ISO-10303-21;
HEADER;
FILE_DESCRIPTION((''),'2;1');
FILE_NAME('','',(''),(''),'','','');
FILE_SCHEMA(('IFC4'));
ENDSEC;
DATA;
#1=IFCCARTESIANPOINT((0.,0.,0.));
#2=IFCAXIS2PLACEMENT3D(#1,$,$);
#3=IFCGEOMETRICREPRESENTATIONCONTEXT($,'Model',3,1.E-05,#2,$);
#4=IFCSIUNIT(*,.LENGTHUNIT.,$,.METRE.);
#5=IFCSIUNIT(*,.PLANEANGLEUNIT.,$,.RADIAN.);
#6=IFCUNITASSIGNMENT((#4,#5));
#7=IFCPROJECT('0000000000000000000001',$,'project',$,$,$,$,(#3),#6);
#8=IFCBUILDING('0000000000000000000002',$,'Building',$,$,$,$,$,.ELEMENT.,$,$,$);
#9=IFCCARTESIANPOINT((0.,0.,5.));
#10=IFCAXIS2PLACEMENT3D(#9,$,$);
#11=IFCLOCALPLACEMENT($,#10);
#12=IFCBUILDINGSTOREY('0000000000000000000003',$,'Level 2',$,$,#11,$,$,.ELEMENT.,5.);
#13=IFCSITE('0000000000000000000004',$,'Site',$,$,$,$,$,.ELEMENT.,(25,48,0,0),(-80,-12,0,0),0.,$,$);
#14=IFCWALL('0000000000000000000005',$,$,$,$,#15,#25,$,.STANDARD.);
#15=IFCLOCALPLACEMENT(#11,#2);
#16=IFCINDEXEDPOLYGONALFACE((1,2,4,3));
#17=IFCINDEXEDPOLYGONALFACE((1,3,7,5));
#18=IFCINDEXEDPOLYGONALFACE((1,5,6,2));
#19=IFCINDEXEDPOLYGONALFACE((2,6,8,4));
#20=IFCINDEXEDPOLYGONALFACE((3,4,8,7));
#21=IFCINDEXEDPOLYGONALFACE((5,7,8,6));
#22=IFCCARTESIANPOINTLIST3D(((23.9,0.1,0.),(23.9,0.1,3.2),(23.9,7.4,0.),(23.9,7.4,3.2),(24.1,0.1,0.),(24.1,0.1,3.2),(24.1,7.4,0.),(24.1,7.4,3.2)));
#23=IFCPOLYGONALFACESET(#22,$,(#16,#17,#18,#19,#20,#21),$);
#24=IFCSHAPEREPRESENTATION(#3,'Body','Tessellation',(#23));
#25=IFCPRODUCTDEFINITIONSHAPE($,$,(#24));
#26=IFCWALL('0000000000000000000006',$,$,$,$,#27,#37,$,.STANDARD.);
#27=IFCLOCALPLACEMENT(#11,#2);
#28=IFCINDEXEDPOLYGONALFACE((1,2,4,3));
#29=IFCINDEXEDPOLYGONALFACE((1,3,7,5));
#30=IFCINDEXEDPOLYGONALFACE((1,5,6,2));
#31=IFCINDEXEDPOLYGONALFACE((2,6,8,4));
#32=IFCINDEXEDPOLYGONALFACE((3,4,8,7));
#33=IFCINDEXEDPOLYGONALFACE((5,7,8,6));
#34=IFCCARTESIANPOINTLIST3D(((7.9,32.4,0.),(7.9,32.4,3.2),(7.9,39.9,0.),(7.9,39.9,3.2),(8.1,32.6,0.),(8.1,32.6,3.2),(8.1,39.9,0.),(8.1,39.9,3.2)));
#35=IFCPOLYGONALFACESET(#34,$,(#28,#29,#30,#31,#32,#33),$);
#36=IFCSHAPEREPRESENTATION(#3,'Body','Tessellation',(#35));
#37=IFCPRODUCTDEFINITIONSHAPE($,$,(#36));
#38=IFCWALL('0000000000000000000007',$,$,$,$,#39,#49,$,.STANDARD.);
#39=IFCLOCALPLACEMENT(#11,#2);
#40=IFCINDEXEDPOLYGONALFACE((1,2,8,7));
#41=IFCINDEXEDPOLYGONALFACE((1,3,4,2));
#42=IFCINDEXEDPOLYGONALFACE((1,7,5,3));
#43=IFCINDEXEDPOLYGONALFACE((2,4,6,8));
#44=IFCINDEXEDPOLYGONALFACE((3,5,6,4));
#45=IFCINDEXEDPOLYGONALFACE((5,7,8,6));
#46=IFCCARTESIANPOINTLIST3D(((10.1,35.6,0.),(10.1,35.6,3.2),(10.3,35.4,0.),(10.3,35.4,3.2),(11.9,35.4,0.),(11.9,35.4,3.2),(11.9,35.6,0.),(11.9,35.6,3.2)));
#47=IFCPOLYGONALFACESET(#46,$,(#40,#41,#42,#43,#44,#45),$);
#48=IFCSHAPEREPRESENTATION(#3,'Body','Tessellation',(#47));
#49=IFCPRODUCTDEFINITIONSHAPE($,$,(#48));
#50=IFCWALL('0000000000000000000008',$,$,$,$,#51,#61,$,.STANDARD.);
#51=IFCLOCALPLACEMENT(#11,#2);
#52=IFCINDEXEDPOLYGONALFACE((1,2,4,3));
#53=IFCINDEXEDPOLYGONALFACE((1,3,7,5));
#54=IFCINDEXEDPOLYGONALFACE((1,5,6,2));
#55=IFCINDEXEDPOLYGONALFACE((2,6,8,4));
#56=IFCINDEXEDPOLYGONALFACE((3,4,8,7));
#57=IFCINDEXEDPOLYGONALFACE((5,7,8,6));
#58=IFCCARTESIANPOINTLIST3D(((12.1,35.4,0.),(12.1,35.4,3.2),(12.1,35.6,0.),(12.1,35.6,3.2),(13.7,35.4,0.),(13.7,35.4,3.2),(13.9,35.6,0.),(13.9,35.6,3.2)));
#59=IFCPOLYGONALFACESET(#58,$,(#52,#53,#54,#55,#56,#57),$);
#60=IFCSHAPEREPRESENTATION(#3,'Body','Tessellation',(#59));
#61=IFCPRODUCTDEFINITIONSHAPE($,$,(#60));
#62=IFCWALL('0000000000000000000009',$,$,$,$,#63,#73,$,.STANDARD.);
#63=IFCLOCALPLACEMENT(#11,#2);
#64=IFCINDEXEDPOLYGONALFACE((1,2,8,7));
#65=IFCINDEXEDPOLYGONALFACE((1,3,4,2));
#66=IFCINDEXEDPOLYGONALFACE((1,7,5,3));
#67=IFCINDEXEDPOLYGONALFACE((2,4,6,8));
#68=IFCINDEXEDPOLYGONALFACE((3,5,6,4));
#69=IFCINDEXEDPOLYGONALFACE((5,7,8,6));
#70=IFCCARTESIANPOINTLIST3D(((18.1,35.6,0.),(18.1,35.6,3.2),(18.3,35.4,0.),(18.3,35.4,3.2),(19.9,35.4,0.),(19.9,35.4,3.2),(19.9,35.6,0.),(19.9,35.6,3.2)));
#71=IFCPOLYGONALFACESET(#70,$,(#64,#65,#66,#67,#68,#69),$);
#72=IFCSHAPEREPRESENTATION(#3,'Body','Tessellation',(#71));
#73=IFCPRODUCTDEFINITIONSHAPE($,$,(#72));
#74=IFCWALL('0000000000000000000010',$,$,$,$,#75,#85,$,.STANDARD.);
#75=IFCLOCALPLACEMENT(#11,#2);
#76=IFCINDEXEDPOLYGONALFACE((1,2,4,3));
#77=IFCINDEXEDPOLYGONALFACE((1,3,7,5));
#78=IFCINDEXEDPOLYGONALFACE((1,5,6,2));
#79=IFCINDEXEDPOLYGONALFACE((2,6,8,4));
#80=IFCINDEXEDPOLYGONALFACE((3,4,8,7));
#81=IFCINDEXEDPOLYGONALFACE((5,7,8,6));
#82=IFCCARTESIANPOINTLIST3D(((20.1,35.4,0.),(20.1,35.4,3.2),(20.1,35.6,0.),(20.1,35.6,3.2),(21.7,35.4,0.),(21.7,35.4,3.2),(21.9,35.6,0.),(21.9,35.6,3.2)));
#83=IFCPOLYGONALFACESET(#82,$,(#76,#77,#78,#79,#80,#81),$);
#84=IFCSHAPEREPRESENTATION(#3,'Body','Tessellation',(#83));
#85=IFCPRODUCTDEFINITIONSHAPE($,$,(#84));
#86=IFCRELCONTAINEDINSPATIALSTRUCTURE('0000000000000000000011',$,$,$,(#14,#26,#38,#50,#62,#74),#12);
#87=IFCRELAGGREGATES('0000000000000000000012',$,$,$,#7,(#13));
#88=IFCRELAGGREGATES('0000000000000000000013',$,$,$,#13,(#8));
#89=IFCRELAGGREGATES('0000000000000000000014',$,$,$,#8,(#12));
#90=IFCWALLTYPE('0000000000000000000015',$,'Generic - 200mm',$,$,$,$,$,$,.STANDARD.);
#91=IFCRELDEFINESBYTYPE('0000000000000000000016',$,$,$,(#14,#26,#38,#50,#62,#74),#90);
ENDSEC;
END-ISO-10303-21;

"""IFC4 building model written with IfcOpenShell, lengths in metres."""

from ifc_helpers import new_model, si_unit, frame, origin, place, context, project, spatial, polyline, outline, extrude, type_object, element, save


model = new_model("IFC4")

# Units and contexts
model_context = context("Model", 3, precision=1e-05, world=origin())
ifc_project = project(units=[si_unit("LENGTHUNIT", "METRE"), si_unit("PLANEANGLEUNIT", "RADIAN")], contexts=[model_context])

# Site, building, storey
site = spatial("IfcSite", under=ifc_project, Name="Site", CompositionType="ELEMENT", RefLatitude=(25, 48, 0, 0), RefLongitude=(-80, -12, 0, 0), RefElevation=0.0)
building = spatial("IfcBuilding", under=site, Name="Building", CompositionType="ELEMENT")
storey_placement = place(None, frame((0.0, 0.0, 5.0)))
storey = spatial("IfcBuildingStorey", under=building, at=storey_placement, Name="Level 2", CompositionType="ELEMENT", Elevation=5.0)

# Shared definitions
wall_type = type_object("IfcWallType", Name="Generic - 200mm", PredefinedType="STANDARD")

# Walls
wall_1_placement = place(None, frame((24.0, 7.5, 5.0), z_axis=(0.0, 0.0, 1.0), x_axis=(0.0, -1.0, 0.0)))
element("IfcWall", 1, at=wall_1_placement, inside=storey, type_object=wall_type, PredefinedType="STANDARD", context=model_context, shape_type="SweptSolid", body=[
    extrude(outline(polyline([(0.1, -0.1), (7.4, -0.1), (7.4, 0.1), (0.1, 0.1), (0.1, -0.1)])), origin(), (0.0, 0.0, 1.0), 3.2),
])
wall_2_placement = place(None, frame((8.0, 32.5, 5.0), z_axis=(0.0, 0.0, 1.0), x_axis=(0.0, 1.0, 0.0)))
element("IfcWall", 2, at=wall_2_placement, inside=storey, type_object=wall_type, PredefinedType="STANDARD", context=model_context, shape_type="SweptSolid", body=[
    extrude(outline(polyline([(0.1, -0.1), (7.4, -0.1), (7.4, 0.1), (-0.1, 0.1), (0.1, -0.1)])), origin(), (0.0, 0.0, 1.0), 3.2),
])
wall_3_placement = place(None, frame((10.2, 35.5, 5.0), z_axis=(0.0, 0.0, 1.0), x_axis=(1.0, 0.0, 0.0)))
element("IfcWall", 3, at=wall_3_placement, inside=storey, type_object=wall_type, PredefinedType="STANDARD", context=model_context, shape_type="SweptSolid", body=[
    extrude(outline(polyline([(0.1, -0.1), (1.7, -0.1), (1.7, 0.1), (-0.1, 0.1), (0.1, -0.1)])), origin(), (0.0, 0.0, 1.0), 3.2),
])
wall_4_placement = place(None, frame((13.8, 35.5, 5.0), z_axis=(0.0, 0.0, 1.0), x_axis=(-1.0, 0.0, 0.0)))
element("IfcWall", 4, at=wall_4_placement, inside=storey, type_object=wall_type, PredefinedType="STANDARD", context=model_context, shape_type="SweptSolid", body=[
    extrude(outline(polyline([(-0.1, -0.1), (1.7, -0.1), (1.7, 0.1), (0.1, 0.1), (-0.1, -0.1)])), origin(), (0.0, 0.0, 1.0), 3.2),
])
wall_5_placement = place(None, frame((18.2, 35.5, 5.0), z_axis=(0.0, 0.0, 1.0), x_axis=(1.0, 0.0, 0.0)))
element("IfcWall", 5, at=wall_5_placement, inside=storey, type_object=wall_type, PredefinedType="STANDARD", context=model_context, shape_type="SweptSolid", body=[
    extrude(outline(polyline([(0.1, -0.1), (1.7, -0.1), (1.7, 0.1), (-0.1, 0.1), (0.1, -0.1)])), origin(), (0.0, 0.0, 1.0), 3.2),
])
wall_6_placement = place(None, frame((21.8, 35.5, 5.0), z_axis=(0.0, 0.0, 1.0), x_axis=(-1.0, 0.0, 0.0)))
element("IfcWall", 6, at=wall_6_placement, inside=storey, type_object=wall_type, PredefinedType="STANDARD", context=model_context, shape_type="SweptSolid", body=[
    extrude(outline(polyline([(-0.1, -0.1), (1.7, -0.1), (1.7, 0.1), (0.1, 0.1), (-0.1, -0.1)])), origin(), (0.0, 0.0, 1.0), 3.2),
])

save(model, "model.ifc")
